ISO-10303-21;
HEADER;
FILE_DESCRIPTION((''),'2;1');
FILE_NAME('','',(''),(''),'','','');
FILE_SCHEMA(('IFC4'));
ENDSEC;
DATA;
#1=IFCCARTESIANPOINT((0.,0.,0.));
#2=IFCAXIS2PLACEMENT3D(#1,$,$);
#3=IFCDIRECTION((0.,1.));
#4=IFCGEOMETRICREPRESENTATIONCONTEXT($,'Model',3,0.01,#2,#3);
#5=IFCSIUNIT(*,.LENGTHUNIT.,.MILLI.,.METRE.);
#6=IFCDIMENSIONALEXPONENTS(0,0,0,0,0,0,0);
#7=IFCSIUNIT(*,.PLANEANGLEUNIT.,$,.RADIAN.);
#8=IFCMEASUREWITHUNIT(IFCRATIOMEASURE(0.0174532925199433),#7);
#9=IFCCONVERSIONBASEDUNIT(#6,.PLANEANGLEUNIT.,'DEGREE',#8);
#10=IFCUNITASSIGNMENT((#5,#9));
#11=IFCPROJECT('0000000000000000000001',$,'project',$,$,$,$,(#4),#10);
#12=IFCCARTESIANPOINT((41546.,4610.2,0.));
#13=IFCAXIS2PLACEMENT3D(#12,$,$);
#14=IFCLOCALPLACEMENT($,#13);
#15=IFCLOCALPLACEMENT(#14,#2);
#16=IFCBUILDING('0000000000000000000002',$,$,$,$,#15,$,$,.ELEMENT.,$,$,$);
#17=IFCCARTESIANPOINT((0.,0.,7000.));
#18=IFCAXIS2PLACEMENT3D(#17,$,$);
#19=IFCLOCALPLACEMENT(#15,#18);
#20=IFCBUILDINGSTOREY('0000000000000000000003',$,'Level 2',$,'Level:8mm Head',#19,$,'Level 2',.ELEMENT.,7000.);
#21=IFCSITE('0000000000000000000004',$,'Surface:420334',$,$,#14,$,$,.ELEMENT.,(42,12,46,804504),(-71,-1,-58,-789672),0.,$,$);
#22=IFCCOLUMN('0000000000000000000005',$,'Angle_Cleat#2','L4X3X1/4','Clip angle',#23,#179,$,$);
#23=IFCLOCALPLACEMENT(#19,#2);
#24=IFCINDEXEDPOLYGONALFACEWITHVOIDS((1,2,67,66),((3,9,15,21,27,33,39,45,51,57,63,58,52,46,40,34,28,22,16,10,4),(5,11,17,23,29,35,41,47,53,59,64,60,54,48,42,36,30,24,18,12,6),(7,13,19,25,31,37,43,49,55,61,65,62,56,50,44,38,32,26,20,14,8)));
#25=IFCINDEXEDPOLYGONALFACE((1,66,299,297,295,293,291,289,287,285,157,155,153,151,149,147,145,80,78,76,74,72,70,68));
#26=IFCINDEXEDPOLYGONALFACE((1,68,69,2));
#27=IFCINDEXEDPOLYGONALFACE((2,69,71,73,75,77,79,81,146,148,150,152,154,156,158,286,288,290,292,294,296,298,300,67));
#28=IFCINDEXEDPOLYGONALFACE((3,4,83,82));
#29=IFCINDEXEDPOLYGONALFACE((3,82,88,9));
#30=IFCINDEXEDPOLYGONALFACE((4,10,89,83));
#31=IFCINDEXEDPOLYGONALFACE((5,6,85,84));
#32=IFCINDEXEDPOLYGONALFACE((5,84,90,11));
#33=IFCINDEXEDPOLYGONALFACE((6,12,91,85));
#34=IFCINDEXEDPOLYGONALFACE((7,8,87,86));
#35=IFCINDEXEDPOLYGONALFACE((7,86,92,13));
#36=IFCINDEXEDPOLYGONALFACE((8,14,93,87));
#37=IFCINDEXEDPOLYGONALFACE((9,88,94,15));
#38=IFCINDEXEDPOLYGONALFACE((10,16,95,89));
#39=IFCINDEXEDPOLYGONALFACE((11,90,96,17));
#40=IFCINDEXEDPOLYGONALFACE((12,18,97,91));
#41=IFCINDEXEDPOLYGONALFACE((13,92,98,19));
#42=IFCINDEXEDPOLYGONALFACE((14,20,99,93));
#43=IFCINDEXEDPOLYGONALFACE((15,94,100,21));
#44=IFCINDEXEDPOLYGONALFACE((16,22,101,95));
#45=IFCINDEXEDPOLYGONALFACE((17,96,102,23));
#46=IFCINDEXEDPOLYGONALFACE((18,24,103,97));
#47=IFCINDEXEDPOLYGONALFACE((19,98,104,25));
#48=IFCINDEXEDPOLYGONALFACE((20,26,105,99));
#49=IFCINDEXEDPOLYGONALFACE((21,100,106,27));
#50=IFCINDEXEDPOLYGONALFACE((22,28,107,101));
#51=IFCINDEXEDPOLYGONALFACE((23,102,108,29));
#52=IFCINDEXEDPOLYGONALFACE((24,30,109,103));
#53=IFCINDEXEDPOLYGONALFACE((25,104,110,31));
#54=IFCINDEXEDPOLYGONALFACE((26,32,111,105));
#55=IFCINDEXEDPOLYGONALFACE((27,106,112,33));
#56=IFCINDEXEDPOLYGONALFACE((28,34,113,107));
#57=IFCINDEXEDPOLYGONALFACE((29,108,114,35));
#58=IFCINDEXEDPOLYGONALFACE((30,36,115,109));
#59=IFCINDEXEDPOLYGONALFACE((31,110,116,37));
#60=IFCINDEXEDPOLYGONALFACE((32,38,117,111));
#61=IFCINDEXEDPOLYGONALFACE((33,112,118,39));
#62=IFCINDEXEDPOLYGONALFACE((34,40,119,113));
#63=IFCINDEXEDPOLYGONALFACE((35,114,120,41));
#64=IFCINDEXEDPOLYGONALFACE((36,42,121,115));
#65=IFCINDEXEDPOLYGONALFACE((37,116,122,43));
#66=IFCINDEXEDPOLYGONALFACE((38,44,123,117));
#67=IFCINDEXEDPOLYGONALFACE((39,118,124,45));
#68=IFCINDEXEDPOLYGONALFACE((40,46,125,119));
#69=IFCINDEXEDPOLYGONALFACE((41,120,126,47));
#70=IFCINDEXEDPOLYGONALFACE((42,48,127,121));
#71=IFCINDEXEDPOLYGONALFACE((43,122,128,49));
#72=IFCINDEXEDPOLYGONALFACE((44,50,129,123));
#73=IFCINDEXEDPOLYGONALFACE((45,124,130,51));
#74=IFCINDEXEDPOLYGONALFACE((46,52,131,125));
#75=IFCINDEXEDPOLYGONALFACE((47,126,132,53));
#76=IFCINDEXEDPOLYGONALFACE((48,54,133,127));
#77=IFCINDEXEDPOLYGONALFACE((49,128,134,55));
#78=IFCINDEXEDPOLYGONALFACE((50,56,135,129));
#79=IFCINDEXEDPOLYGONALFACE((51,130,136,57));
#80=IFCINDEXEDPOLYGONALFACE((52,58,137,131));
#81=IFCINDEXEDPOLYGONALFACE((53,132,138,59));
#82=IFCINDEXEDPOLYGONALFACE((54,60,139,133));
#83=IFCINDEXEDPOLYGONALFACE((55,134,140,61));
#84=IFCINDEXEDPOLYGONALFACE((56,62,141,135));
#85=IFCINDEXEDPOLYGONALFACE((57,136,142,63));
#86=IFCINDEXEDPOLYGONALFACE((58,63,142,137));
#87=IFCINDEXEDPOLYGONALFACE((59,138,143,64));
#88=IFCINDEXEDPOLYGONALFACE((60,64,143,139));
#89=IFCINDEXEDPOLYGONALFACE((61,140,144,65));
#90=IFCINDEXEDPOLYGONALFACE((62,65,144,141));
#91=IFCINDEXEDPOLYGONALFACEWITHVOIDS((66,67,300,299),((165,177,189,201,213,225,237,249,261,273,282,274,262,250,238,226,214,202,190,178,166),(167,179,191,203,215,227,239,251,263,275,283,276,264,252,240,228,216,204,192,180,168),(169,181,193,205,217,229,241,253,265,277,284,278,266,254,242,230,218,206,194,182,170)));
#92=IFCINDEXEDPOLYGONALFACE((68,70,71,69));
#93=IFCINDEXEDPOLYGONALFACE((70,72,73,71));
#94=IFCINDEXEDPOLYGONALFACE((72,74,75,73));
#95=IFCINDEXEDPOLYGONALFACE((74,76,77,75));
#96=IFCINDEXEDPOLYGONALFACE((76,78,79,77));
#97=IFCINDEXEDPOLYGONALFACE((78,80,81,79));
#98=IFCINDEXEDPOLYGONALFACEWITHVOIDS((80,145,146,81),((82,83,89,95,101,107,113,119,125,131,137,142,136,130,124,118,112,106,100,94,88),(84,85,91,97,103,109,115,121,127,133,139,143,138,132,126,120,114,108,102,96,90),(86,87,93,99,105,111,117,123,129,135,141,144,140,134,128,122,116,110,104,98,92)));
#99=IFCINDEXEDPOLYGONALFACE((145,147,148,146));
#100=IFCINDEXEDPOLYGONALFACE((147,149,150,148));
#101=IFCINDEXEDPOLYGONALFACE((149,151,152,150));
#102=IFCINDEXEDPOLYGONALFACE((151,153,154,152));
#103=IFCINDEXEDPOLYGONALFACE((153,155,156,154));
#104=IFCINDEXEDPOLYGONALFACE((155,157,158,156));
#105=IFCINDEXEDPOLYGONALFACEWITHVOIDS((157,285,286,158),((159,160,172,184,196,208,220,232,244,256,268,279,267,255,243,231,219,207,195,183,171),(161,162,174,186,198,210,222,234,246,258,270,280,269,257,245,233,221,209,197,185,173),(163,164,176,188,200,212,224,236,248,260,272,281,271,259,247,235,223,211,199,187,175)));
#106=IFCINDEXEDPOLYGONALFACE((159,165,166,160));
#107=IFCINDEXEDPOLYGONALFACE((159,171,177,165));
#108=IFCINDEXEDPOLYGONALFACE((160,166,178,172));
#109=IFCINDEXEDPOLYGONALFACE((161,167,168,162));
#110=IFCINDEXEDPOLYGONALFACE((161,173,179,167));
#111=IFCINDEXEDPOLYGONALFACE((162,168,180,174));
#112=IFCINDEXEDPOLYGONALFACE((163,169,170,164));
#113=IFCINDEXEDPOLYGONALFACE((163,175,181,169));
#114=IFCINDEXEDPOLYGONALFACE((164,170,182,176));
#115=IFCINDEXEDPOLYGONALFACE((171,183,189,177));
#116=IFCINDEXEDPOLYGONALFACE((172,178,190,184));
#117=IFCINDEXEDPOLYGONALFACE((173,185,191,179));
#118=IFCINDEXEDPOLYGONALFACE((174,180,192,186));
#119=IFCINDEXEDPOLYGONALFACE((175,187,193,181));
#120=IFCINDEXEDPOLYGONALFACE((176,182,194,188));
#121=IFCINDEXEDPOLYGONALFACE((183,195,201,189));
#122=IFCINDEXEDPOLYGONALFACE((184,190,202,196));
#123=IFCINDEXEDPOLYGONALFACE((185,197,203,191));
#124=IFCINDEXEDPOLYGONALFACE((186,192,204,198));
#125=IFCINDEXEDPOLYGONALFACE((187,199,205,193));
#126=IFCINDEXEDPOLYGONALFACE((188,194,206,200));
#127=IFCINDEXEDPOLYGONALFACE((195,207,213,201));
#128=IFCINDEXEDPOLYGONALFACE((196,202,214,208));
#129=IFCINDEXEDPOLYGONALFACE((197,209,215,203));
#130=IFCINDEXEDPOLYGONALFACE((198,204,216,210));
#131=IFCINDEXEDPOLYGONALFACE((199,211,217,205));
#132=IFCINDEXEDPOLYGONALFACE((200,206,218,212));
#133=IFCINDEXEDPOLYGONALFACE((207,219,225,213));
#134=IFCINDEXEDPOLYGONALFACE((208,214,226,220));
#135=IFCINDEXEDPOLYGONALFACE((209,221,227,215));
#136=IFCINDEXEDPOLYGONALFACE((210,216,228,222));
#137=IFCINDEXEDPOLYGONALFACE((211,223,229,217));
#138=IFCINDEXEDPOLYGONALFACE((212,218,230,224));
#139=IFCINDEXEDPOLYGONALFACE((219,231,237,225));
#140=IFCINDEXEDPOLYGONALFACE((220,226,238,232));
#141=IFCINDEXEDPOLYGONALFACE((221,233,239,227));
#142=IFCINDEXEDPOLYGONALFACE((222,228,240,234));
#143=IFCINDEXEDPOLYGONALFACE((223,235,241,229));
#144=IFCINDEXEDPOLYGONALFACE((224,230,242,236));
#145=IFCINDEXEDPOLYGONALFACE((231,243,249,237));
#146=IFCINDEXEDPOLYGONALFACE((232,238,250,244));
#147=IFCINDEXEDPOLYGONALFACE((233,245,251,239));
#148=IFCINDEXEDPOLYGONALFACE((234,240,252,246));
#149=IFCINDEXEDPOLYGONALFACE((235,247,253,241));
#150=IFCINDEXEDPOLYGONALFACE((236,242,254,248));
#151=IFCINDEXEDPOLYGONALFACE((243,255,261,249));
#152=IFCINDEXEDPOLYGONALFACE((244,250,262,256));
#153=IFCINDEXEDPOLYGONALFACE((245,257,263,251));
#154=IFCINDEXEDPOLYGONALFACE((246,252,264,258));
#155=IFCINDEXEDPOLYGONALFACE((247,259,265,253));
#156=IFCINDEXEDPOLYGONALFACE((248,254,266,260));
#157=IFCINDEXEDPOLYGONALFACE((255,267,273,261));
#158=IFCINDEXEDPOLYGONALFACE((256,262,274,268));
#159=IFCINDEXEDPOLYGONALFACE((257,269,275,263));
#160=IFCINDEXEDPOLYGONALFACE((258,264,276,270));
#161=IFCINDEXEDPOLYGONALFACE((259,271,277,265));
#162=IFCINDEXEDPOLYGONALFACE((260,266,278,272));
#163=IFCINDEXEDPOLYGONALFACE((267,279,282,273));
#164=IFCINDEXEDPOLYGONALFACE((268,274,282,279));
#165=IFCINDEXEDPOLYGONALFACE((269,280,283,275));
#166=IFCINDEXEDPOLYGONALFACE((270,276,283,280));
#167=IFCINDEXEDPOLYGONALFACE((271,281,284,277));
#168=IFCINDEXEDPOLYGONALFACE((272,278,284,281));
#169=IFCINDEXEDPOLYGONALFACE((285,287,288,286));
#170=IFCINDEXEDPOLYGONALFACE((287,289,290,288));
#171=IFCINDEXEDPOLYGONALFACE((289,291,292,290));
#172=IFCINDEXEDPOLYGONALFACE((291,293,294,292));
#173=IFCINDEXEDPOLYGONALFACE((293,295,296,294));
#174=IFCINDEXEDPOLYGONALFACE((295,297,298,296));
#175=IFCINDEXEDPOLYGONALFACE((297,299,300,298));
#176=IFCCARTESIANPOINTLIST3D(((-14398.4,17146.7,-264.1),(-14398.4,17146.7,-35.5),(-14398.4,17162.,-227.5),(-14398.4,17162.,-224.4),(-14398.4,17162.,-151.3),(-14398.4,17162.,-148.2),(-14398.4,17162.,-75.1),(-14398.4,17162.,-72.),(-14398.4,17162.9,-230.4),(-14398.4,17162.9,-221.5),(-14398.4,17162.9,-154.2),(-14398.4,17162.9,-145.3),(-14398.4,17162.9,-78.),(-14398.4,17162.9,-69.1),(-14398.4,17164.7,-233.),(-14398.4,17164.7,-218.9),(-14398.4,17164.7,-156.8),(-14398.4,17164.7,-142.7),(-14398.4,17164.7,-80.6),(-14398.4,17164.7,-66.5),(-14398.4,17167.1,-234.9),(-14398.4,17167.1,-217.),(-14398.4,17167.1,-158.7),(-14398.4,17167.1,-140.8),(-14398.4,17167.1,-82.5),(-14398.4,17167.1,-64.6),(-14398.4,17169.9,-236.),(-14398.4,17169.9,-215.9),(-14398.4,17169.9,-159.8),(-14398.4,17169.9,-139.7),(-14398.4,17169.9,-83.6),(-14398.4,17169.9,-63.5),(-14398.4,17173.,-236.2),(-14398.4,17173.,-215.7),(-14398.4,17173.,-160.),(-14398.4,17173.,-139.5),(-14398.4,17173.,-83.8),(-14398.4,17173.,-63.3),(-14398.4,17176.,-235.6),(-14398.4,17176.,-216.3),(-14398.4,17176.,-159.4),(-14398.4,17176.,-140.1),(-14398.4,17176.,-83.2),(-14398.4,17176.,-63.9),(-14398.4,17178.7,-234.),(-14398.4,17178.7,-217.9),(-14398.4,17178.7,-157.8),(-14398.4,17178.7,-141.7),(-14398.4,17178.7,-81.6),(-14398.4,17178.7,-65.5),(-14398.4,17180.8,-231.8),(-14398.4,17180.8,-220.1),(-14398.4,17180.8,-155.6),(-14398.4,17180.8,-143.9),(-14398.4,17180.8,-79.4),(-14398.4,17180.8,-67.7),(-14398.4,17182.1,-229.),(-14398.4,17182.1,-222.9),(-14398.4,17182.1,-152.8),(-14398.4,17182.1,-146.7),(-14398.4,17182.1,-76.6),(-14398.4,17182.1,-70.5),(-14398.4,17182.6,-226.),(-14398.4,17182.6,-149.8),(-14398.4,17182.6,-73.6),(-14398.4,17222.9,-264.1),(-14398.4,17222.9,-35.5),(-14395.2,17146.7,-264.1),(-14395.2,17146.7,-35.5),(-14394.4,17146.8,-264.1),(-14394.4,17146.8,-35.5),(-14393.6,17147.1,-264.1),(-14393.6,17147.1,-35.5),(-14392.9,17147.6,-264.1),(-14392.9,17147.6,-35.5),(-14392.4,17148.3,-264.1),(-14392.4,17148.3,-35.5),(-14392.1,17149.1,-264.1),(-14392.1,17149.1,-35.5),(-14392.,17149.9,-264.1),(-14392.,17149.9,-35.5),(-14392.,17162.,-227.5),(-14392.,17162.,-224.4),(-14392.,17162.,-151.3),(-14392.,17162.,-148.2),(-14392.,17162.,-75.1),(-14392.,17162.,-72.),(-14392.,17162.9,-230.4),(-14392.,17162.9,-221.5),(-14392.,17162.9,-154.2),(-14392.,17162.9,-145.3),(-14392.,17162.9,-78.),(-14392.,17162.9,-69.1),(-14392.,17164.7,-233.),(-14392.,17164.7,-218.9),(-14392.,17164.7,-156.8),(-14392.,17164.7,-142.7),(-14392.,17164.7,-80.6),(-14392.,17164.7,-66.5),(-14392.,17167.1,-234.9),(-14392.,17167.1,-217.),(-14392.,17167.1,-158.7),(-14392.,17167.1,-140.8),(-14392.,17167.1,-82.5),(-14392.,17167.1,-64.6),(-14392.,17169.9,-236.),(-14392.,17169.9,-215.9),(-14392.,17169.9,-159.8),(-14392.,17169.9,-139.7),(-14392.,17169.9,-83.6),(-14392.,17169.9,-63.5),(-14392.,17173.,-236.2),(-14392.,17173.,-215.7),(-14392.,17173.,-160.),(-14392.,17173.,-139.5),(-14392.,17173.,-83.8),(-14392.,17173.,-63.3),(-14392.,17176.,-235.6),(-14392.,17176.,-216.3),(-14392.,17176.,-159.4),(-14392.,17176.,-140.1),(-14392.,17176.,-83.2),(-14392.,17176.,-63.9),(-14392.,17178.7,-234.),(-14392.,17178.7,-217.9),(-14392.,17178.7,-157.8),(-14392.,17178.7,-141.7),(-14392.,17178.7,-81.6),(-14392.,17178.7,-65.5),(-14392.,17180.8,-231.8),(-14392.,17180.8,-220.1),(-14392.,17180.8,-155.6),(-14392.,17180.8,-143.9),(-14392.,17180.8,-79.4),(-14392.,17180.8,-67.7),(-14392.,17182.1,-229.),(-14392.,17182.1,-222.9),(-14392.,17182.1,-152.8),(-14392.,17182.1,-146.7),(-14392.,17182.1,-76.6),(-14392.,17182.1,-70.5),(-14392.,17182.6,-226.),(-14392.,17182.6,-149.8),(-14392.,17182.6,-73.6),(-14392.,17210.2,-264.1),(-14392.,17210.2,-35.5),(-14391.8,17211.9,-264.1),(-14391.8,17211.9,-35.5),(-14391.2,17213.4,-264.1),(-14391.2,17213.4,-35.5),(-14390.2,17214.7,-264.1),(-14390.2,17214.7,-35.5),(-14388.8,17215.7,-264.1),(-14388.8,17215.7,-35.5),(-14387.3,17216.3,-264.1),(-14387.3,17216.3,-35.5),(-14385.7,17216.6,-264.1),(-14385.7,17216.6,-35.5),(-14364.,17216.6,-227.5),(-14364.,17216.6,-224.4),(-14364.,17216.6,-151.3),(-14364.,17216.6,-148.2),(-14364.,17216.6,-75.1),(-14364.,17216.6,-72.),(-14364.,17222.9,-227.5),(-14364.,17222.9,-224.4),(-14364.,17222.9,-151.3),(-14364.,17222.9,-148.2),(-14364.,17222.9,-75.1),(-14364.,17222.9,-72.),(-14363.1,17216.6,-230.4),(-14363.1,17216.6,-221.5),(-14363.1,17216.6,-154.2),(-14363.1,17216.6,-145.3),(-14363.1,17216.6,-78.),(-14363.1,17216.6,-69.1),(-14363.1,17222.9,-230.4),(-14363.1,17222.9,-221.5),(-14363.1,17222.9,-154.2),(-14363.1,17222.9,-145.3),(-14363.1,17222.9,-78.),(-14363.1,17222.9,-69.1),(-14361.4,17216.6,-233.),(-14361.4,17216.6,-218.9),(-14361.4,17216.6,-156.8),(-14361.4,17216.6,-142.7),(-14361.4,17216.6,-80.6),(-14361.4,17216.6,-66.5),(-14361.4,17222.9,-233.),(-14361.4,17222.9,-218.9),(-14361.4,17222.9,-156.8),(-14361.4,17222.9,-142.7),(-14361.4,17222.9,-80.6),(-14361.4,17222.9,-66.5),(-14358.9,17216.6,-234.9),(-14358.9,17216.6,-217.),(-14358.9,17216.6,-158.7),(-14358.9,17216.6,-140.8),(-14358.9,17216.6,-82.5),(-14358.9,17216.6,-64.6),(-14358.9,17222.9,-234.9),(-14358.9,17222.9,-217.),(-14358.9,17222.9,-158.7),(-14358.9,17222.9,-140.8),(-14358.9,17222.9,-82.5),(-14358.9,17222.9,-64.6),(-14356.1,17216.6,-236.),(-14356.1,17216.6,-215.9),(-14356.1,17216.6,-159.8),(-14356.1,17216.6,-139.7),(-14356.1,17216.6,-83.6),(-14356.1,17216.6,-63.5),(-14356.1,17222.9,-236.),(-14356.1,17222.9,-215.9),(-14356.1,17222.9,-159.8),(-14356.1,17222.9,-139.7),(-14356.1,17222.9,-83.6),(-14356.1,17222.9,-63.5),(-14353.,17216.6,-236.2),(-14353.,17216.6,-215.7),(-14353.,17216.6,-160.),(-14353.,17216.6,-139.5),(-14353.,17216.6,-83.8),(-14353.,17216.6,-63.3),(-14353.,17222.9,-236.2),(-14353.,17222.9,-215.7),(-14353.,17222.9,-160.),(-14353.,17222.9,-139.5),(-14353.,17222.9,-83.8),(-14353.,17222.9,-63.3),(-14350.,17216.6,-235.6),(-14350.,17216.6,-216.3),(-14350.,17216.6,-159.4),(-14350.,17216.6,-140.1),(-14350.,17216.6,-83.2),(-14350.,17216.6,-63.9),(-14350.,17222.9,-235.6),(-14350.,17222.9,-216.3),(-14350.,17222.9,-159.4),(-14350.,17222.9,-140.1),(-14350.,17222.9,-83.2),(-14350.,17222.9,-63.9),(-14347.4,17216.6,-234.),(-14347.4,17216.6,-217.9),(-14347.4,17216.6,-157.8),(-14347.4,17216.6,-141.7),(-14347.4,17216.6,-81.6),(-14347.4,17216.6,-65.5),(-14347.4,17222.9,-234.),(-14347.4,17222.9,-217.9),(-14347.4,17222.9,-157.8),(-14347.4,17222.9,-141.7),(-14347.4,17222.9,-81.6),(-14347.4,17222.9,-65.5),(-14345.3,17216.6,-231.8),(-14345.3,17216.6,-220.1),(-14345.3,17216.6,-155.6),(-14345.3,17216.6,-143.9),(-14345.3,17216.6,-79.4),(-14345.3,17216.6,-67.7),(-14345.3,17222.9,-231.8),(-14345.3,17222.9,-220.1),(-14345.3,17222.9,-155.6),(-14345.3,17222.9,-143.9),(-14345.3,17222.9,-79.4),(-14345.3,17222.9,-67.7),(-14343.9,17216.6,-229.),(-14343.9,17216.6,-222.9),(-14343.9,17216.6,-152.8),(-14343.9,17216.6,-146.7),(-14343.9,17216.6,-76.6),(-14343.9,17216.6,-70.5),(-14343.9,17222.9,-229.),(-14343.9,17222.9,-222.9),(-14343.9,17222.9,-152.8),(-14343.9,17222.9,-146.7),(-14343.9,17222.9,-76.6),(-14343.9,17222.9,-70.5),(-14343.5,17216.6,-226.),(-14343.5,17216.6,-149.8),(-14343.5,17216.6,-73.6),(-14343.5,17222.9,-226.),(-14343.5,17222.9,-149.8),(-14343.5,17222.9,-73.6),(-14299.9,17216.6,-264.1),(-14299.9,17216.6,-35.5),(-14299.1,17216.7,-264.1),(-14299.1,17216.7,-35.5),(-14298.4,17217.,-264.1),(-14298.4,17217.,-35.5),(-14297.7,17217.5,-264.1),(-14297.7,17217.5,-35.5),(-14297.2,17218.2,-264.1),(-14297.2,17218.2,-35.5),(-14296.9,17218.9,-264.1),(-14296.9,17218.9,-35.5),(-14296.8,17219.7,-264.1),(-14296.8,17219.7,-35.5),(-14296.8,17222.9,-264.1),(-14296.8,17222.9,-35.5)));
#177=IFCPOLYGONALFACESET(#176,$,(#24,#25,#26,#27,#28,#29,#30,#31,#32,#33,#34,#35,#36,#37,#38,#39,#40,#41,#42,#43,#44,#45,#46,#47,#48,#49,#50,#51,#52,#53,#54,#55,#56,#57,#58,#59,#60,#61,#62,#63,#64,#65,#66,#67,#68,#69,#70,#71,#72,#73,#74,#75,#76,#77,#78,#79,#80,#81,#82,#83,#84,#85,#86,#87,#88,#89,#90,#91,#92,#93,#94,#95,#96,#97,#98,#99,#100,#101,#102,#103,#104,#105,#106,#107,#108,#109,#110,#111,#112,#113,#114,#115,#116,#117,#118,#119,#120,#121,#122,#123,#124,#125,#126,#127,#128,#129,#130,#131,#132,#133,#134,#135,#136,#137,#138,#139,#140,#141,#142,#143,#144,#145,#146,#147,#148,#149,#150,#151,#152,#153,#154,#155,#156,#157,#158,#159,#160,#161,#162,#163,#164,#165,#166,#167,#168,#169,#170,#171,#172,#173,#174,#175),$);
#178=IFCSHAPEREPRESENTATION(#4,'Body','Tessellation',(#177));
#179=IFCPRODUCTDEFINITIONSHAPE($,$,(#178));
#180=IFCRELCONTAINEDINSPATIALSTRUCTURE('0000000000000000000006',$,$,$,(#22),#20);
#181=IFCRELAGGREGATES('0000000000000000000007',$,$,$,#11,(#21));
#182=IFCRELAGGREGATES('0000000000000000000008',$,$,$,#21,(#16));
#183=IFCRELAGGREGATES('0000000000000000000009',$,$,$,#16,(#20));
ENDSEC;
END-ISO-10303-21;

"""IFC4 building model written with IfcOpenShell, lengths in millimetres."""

from ifc_helpers import new_model, entity, si_unit, converted_unit, direction, frame, frame_2d, origin, origin_2d_with_axis, place, context, project, spatial, circle, l_section, extrude, element, save


model = new_model("IFC4")

# Units and contexts
model_context = context("Model", 3, precision=0.01, world=origin(), true_north=direction((0.0, 1.0)))
ifc_project = project(units=[si_unit("LENGTHUNIT", "METRE", prefix="MILLI"), converted_unit("PLANEANGLEUNIT", "DEGREE", entity("IfcRatioMeasure", 0.0174532925199433), si_unit("PLANEANGLEUNIT", "RADIAN"), dimensions=[0, 0, 0, 0, 0, 0, 0])], contexts=[model_context])

# Site, building, storey
site_placement = place(None, frame((41546.0, 4610.2, 0.0)))
site = spatial("IfcSite", under=ifc_project, at=site_placement, Name="Surface:420334", CompositionType="ELEMENT", RefLatitude=(42, 12, 46, 804504), RefLongitude=(-71, -1, -58, -789672), RefElevation=0.0)
building_placement = place(site_placement, origin())
building = spatial("IfcBuilding", under=site, at=building_placement, CompositionType="ELEMENT")
storey_placement = place(building_placement, frame((0.0, 0.0, 7000.0)))
storey = spatial("IfcBuildingStorey", under=building, at=storey_placement, Name="Level 2", ObjectType="Level:8mm Head", LongName="Level 2", CompositionType="ELEMENT", Elevation=7000.0)

# Column, openings
column_1_placement = place(storey_placement, frame((-14367.2, 17204.6, -35.5), z_axis=(0.0, 0.0, 1.0), x_axis=(0.0, -1.0, 0.0)))
column_1 = element("IfcColumn", 1, at=column_1_placement, inside=storey, Name="Angle_Cleat#2", Description="L4X3X1/4", ObjectType="Clip angle", context=model_context, shape_type="SweptSolid", body=[
    extrude(l_section(Depth=101.6, Width=76.2, Thickness=6.3, FilletRadius=6.3, EdgeRadius=3.2, at=frame_2d((19.8, 19.7))), origin(), (0.0, 0.0, -1.0), 228.6),
])
opening_1_placement = place(column_1_placement, frame((32.4, -31.5, -114.3), z_axis=(0.0, 1.0, 0.0), x_axis=(-1.0, 0.0, 0.0)))
element("IfcOpeningElement", 2, at=opening_1_placement, cuts=column_1, ObjectType="Opening", context=model_context, shape_type="SweptSolid", body=[
    extrude(circle(Radius=10.3, at=origin_2d_with_axis()), origin(), (0.0, 0.0, 1.0), 7.3),
])
opening_2_placement = place(column_1_placement, frame((32.4, -31.5, -114.3), z_axis=(0.0, 1.0, 0.0), x_axis=(-1.0, 0.0, 0.0)))
element("IfcOpeningElement", 3, at=opening_2_placement, cuts=column_1, ObjectType="Opening", context=model_context, shape_type="SweptSolid", body=[
    extrude(circle(Radius=10.3, at=frame_2d((0.0, 76.2), x_axis=(1.0, 0.0))), origin(), (0.0, 0.0, 1.0), 7.3),
])
opening_3_placement = place(column_1_placement, frame((32.4, -31.5, -114.3), z_axis=(0.0, 1.0, 0.0), x_axis=(-1.0, 0.0, 0.0)))
element("IfcOpeningElement", 4, at=opening_3_placement, cuts=column_1, ObjectType="Opening", context=model_context, shape_type="SweptSolid", body=[
    extrude(circle(Radius=10.3, at=frame_2d((0.0, -76.2), x_axis=(1.0, 0.0))), origin(), (0.0, 0.0, 1.0), 7.3),
])
opening_4_placement = place(column_1_placement, frame((-11.6, 13.5, -114.3), z_axis=(-1.0, 0.0, 0.0), x_axis=(0.0, 1.0, 0.0)))
element("IfcOpeningElement", 5, at=opening_4_placement, cuts=column_1, ObjectType="Opening", context=model_context, shape_type="SweptSolid", body=[
    extrude(circle(Radius=10.3, at=origin_2d_with_axis()), origin(), (0.0, 0.0, 1.0), 7.3),
])
opening_5_placement = place(column_1_placement, frame((-11.6, 13.5, -114.3), z_axis=(-1.0, 0.0, 0.0), x_axis=(0.0, 1.0, 0.0)))
element("IfcOpeningElement", 6, at=opening_5_placement, cuts=column_1, ObjectType="Opening", context=model_context, shape_type="SweptSolid", body=[
    extrude(circle(Radius=10.3, at=frame_2d((0.0, 76.2), x_axis=(1.0, 0.0))), origin(), (0.0, 0.0, 1.0), 7.3),
])
opening_6_placement = place(column_1_placement, frame((-11.6, 13.5, -114.3), z_axis=(-1.0, 0.0, 0.0), x_axis=(0.0, 1.0, 0.0)))
element("IfcOpeningElement", 7, at=opening_6_placement, cuts=column_1, ObjectType="Opening", context=model_context, shape_type="SweptSolid", body=[
    extrude(circle(Radius=10.3, at=frame_2d((0.0, -76.2), x_axis=(1.0, 0.0))), origin(), (0.0, 0.0, 1.0), 7.3),
])

save(model, "model.ifc")
